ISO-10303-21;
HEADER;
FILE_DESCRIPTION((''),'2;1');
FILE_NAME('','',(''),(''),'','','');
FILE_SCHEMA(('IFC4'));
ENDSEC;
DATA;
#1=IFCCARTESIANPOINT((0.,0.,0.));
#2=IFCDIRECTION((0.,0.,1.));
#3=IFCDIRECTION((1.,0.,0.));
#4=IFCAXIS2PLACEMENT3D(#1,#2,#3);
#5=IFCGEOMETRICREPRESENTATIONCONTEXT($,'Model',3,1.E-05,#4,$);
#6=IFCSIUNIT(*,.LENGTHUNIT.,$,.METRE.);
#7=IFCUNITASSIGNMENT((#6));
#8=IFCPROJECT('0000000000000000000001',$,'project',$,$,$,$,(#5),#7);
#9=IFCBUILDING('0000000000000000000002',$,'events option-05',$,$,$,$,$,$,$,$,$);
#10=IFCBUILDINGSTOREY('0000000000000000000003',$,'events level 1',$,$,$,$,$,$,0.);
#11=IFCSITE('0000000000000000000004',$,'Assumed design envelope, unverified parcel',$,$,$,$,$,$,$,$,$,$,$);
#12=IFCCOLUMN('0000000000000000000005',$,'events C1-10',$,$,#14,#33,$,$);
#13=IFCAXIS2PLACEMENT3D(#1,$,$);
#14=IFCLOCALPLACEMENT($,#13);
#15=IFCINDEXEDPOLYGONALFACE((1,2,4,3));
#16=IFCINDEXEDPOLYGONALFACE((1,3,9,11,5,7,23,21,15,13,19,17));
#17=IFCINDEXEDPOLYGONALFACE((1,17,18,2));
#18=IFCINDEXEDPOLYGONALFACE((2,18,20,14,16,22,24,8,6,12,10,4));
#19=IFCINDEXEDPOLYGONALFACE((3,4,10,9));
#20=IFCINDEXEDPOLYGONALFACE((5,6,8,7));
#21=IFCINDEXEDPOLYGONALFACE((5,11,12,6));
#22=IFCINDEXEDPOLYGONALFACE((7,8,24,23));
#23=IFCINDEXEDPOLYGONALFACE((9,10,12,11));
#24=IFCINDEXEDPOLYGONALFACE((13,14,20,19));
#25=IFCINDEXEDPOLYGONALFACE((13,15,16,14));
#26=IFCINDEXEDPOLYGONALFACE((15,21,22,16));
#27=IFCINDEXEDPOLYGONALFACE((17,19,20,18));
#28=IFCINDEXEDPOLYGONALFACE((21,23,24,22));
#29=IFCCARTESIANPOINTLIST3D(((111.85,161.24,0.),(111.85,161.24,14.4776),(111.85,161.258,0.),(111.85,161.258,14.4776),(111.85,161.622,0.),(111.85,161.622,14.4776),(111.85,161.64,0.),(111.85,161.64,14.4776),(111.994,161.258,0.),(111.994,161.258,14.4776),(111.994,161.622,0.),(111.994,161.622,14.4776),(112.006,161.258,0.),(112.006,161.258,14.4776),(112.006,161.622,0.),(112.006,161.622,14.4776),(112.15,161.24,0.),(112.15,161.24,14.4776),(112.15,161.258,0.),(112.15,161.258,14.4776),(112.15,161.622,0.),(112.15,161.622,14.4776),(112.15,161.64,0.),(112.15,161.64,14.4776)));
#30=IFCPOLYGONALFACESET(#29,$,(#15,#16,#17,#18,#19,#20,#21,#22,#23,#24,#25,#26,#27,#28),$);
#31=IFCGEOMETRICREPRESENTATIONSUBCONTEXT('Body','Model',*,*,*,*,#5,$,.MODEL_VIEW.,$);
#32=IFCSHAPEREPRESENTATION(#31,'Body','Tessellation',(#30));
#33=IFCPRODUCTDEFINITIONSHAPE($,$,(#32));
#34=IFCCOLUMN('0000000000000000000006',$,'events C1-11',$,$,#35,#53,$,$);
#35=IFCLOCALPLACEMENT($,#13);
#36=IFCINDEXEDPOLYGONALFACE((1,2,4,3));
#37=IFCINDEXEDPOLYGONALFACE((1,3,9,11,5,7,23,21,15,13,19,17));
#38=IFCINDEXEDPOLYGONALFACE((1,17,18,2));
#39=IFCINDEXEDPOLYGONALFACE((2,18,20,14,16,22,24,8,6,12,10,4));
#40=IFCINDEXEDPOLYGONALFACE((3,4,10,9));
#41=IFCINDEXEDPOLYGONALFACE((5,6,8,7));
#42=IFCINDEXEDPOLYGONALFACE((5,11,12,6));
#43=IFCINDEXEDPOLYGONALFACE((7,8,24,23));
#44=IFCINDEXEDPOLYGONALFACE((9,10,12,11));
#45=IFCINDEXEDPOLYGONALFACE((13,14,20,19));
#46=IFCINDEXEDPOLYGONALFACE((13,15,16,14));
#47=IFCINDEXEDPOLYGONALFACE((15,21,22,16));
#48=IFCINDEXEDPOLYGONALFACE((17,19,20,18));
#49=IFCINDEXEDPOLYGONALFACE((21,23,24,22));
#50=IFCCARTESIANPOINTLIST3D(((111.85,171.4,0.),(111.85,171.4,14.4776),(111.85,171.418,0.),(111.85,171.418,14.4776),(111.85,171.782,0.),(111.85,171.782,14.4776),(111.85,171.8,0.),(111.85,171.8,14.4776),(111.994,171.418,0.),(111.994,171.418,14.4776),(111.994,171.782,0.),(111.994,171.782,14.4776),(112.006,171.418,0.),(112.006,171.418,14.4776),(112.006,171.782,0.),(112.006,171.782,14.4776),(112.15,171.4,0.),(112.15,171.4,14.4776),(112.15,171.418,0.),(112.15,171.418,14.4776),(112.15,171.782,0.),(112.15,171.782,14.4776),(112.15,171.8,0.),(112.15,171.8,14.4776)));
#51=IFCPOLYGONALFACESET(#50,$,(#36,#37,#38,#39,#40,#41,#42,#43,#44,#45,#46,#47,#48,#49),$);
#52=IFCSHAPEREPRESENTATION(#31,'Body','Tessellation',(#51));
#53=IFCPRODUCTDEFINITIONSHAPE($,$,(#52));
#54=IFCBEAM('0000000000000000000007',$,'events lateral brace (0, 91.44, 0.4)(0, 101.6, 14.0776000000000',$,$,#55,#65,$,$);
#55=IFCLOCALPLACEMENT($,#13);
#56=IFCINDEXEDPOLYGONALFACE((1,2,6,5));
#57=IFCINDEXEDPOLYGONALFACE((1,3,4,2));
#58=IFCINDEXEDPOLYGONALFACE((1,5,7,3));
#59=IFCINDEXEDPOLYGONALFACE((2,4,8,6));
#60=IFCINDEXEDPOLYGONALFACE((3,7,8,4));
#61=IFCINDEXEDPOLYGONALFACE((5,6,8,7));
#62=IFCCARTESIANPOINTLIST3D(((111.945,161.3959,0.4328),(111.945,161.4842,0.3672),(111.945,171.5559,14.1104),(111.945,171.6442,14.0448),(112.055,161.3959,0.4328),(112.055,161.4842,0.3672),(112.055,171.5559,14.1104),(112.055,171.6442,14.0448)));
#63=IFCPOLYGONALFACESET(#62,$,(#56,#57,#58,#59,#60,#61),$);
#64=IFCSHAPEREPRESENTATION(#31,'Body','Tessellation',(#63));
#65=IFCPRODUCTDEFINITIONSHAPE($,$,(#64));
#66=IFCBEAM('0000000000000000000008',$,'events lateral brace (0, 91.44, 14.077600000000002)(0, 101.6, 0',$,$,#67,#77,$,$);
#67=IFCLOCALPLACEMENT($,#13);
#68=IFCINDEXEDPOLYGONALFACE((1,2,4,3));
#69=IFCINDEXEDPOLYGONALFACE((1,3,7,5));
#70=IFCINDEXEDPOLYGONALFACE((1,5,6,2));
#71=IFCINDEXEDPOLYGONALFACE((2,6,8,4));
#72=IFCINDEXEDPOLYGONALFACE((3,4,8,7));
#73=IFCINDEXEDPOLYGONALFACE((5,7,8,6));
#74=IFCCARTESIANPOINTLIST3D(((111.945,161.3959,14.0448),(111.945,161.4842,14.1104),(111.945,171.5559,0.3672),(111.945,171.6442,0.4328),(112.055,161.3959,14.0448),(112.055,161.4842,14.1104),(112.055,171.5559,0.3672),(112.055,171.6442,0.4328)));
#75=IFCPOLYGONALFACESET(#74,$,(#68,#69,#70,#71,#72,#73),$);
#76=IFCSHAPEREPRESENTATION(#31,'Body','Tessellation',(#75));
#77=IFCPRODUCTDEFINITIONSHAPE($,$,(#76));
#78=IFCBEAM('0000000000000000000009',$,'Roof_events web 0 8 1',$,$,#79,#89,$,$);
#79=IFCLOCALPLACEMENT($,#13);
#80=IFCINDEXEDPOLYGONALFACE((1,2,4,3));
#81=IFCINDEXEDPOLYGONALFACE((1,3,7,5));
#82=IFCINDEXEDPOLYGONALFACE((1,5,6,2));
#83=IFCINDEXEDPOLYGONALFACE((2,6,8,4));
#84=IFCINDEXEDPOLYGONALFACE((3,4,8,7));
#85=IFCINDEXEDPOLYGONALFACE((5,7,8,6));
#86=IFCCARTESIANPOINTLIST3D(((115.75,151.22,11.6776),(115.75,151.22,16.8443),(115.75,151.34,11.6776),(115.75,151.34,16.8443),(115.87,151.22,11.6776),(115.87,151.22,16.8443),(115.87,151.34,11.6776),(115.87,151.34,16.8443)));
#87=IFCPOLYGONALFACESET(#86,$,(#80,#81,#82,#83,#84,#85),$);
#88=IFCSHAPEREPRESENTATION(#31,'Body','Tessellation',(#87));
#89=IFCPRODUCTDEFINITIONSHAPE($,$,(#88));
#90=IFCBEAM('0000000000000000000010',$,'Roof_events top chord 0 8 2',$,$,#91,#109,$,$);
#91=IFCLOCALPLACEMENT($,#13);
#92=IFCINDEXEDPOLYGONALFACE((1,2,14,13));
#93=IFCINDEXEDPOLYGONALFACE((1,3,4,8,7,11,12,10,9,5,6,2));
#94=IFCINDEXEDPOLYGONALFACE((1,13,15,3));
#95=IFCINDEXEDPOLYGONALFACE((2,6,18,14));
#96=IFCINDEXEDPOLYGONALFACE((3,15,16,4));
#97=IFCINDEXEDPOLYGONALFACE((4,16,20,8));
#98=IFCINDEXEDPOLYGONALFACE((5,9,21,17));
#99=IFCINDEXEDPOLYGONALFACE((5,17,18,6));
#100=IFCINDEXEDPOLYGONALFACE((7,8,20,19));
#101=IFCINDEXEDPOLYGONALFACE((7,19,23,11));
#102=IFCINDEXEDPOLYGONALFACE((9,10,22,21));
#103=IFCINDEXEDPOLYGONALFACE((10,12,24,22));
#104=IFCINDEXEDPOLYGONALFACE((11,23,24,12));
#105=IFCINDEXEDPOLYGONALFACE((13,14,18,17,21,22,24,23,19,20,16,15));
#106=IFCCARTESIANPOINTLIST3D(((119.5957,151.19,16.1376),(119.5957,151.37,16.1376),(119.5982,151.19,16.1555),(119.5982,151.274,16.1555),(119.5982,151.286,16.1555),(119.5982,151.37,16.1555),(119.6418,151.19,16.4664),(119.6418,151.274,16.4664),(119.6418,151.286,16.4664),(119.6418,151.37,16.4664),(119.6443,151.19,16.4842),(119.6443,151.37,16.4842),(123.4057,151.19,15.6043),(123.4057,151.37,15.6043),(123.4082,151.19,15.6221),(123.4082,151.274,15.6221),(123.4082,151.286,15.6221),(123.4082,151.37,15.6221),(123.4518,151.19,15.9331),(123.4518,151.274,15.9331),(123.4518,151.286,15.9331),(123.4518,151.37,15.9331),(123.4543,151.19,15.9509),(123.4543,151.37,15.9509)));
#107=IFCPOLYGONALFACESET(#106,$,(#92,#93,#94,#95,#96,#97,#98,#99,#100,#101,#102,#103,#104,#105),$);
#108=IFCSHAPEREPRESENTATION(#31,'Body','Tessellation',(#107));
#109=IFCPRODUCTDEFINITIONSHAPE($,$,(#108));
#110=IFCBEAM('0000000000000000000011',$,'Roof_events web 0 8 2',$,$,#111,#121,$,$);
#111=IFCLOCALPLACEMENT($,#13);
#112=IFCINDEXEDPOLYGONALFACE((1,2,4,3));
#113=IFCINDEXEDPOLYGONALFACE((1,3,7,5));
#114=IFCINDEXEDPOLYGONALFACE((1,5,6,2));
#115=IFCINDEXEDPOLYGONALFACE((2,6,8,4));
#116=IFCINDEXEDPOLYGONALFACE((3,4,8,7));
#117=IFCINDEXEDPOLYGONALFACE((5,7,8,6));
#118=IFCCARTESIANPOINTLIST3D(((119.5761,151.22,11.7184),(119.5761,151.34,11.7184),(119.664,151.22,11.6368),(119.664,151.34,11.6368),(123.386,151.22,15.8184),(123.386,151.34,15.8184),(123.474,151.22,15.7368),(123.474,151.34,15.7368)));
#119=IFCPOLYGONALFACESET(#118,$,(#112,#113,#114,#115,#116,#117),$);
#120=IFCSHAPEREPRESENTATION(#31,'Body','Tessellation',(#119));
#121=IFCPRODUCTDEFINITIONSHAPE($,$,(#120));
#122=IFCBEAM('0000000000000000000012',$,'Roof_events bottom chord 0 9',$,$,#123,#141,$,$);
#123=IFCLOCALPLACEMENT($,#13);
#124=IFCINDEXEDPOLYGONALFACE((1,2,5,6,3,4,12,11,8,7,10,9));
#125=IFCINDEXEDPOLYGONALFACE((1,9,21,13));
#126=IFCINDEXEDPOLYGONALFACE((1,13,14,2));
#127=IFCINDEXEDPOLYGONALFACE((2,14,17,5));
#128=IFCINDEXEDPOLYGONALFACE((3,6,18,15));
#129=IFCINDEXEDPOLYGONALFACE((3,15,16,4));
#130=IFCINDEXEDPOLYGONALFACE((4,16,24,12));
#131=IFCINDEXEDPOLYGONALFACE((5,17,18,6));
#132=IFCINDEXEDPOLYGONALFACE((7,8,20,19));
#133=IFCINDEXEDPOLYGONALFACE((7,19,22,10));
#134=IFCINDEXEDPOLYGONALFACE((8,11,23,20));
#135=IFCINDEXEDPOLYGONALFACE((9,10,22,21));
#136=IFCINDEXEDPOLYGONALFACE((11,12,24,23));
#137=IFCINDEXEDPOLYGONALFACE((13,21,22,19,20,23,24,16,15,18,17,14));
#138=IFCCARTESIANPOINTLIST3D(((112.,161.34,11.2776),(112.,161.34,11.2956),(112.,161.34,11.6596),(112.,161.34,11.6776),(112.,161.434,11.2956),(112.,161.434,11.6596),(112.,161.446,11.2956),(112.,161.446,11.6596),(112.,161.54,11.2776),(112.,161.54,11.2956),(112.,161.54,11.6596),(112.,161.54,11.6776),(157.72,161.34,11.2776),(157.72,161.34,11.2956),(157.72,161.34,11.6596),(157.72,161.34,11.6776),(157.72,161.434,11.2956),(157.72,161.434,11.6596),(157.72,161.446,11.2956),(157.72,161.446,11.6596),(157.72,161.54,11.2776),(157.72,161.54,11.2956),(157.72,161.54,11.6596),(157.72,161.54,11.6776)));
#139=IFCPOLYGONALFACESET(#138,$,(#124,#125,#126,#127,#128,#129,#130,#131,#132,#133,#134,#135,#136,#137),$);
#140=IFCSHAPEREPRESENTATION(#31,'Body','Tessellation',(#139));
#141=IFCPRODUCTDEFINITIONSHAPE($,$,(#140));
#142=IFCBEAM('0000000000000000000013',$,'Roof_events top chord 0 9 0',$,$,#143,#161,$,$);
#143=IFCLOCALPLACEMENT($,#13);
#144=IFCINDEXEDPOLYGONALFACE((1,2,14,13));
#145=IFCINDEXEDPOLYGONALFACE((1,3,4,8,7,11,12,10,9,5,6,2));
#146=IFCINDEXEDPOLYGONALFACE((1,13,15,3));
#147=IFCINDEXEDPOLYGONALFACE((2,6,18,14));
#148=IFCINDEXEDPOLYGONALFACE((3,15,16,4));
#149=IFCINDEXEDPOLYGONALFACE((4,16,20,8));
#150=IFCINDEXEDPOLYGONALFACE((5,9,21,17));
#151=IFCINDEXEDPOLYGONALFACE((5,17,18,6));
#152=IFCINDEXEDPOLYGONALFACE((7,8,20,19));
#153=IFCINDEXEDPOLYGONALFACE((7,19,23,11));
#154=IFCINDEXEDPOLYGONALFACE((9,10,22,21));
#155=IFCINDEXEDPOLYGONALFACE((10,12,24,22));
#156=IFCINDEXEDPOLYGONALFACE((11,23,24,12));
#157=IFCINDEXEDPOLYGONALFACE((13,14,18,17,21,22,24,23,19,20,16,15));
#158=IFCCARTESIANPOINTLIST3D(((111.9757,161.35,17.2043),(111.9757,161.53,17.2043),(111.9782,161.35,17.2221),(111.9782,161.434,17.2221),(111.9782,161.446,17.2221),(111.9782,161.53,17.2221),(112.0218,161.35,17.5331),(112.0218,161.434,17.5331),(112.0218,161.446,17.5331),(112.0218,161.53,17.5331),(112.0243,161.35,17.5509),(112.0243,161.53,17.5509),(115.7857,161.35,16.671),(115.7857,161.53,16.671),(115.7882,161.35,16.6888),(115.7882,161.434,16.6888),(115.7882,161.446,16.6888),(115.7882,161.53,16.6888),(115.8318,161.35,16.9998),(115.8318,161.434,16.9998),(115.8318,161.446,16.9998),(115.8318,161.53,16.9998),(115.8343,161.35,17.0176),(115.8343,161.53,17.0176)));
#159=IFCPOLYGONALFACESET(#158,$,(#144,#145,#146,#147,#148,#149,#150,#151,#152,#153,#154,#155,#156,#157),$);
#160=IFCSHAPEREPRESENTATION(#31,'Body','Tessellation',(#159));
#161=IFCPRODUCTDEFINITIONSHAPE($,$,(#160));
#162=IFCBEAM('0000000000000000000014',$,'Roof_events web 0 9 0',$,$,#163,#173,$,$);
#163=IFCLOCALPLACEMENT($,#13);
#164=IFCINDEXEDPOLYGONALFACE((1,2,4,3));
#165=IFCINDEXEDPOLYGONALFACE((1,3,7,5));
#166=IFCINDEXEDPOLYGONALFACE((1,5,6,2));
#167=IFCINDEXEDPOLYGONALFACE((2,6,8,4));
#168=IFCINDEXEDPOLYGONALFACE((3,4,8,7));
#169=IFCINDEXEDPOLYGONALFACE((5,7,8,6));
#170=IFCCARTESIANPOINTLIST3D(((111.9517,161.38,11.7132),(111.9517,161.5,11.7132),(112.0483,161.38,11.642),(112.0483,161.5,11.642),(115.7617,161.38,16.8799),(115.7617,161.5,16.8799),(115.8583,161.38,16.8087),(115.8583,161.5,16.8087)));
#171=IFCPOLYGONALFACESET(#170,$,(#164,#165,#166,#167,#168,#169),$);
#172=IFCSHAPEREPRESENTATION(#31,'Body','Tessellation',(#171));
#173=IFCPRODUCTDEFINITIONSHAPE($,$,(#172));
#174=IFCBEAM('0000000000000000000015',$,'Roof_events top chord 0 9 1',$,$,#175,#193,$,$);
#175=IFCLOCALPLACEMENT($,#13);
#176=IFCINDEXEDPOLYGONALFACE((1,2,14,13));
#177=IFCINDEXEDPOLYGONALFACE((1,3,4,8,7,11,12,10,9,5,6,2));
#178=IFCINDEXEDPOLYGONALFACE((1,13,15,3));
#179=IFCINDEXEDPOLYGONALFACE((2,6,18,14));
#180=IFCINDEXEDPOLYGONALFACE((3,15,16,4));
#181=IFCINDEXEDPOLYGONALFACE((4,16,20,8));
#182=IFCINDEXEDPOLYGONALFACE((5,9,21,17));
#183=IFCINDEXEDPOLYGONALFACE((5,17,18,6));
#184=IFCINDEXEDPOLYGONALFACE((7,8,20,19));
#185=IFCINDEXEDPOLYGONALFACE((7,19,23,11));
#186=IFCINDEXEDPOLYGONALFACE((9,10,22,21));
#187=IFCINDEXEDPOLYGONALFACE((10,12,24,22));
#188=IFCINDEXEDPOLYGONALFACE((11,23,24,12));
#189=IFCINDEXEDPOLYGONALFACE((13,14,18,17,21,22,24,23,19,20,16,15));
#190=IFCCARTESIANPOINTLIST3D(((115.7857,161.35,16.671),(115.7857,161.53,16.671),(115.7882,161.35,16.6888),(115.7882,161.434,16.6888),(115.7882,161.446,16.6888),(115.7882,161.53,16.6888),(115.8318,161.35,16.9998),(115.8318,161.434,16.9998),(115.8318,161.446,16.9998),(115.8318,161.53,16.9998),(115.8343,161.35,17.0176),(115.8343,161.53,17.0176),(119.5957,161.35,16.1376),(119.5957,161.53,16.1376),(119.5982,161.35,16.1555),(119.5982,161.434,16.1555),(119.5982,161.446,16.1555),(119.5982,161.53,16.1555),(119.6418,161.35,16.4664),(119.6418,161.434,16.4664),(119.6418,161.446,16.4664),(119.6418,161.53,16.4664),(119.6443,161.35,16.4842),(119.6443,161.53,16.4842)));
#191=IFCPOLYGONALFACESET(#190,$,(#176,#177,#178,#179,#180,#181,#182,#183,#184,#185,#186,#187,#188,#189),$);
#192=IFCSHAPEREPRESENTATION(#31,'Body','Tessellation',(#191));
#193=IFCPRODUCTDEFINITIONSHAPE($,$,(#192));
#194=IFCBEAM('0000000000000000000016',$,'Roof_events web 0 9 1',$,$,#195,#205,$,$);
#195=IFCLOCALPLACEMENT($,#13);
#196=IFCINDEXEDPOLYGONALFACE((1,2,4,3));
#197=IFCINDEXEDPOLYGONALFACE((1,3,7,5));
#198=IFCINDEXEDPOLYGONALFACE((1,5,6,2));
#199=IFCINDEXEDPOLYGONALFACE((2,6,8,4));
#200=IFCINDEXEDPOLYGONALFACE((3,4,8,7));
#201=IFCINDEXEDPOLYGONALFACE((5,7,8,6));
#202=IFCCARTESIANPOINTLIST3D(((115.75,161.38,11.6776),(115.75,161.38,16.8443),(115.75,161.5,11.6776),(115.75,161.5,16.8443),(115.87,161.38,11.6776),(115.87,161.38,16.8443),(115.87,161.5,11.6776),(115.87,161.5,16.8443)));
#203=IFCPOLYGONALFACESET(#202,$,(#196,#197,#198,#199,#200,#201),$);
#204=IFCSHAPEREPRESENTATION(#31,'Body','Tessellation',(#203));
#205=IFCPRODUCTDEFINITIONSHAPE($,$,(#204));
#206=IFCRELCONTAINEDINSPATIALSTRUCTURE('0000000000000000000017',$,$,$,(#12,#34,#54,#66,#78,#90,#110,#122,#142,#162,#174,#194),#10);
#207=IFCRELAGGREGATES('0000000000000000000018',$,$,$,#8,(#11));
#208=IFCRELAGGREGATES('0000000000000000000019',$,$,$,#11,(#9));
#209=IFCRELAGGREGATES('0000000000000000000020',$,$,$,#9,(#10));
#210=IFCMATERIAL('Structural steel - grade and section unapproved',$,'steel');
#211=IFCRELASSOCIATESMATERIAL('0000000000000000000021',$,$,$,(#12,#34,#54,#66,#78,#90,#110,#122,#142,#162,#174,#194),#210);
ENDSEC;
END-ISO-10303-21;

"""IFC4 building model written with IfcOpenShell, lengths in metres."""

from ifc_helpers import new_model, si_unit, frame, origin_with_axes, place, context, subcontext, project, spatial, rectangle, i_section, extrude, material, element, save


model = new_model("IFC4")

# Units and contexts
model_context = context("Model", 3, precision=1e-05, world=origin_with_axes())
body_context = subcontext(model_context, "Body", "Model", "MODEL_VIEW")
ifc_project = project(units=[si_unit("LENGTHUNIT", "METRE")], contexts=[model_context])

# Site, building, storey
site = spatial("IfcSite", under=ifc_project, Name="Assumed design envelope, unverified parcel")
building = spatial("IfcBuilding", under=site, Name="events option-05")
storey = spatial("IfcBuildingStorey", under=building, Name="events level 1", Elevation=0.0)

# Columns
ifc_material_1 = material(Name="Structural steel - grade and section unapproved", Category="steel")
for number, where, z_axis, x_axis, name in (
    (1, (112.0, 161.44, 0.0), (0.0, 0.0, 1.0), (-1.0, 0.0, 0.0), "events C1-10"),
    (2, (112.0, 171.6, 0.0), (0.0, 0.0, 1.0), (-1.0, 0.0, 0.0), "events C1-11"),
):
    element("IfcColumn", number, at=place(None, frame(where, z_axis=z_axis, x_axis=x_axis)), inside=storey, material=ifc_material_1, Name=name, context=body_context, shape_type="SweptSolid", body=[
        extrude(i_section(OverallWidth=0.3, OverallDepth=0.4, WebThickness=0.012, FlangeThickness=0.018, FilletRadius=0.0), origin_with_axes(), (0.0, 0.0, 1.0), 14.4776),
    ])

# Beams
for number, where, z_axis, x_axis, name in (
    (3, (112.0, 161.44, 0.4), (0.0, 0.596305, 0.802758), (-1.0, 0.0, 0.0), "events lateral brace (0, 91.44, 0.4)(0, 101.6, 14.0776000000000"),
    (4, (112.0, 161.44, 14.0776), (0.0, 0.596305, -0.802758), (-1.0, 0.0, 0.0), "events lateral brace (0, 91.44, 14.077600000000002)(0, 101.6, 0"),
):
    element("IfcBeam", number, at=place(None, frame(where, z_axis=z_axis, x_axis=x_axis)), inside=storey, material=ifc_material_1, Name=name, context=body_context, shape_type="SweptSolid", body=[
        extrude(rectangle(XDim=0.11, YDim=0.11), origin_with_axes(), (0.0, 0.0, 1.0), 17.0383),
    ])
beam_1_placement = place(None, frame((115.81, 151.28, 11.6776), z_axis=(0.0, 0.0, 1.0), x_axis=(-1.0, 0.0, 0.0)))
element("IfcBeam", 5, at=beam_1_placement, inside=storey, material=ifc_material_1, Name="Roof_events web 0 8 1", context=body_context, shape_type="SweptSolid", body=[
    extrude(rectangle(XDim=0.12, YDim=0.12), origin_with_axes(), (0.0, 0.0, 1.0), 5.1667),
])
beam_2_placement = place(None, frame((119.62, 151.28, 16.3109), z_axis=(0.990344, 0.0, -0.138631), x_axis=(0.0, 1.0, 0.0)))
element("IfcBeam", 6, at=beam_2_placement, inside=storey, material=ifc_material_1, Name="Roof_events top chord 0 8 2", context=body_context, shape_type="SweptSolid", body=[
    extrude(i_section(OverallWidth=0.18, OverallDepth=0.35, WebThickness=0.012, FlangeThickness=0.018, FilletRadius=0.0), origin_with_axes(), (0.0, 0.0, 1.0), 3.8471),
])
beam_3_placement = place(None, frame((119.62, 151.28, 11.6776), z_axis=(0.680725, 0.0, 0.732539), x_axis=(0.0, 1.0, 0.0)))
element("IfcBeam", 7, at=beam_3_placement, inside=storey, material=ifc_material_1, Name="Roof_events web 0 8 2", context=body_context, shape_type="SweptSolid", body=[
    extrude(rectangle(XDim=0.12, YDim=0.12), origin_with_axes(), (0.0, 0.0, 1.0), 5.597),
])
beam_4_placement = place(None, frame((112.0, 161.44, 11.4776), z_axis=(1.0, 0.0, 0.0), x_axis=(0.0, 1.0, 0.0)))
element("IfcBeam", 8, at=beam_4_placement, inside=storey, material=ifc_material_1, Name="Roof_events bottom chord 0 9", context=body_context, shape_type="SweptSolid", body=[
    extrude(i_section(OverallWidth=0.2, OverallDepth=0.4, WebThickness=0.012, FlangeThickness=0.018, FilletRadius=0.0), origin_with_axes(), (0.0, 0.0, 1.0), 45.72),
])
beam_5_placement = place(None, frame((112.0, 161.44, 17.3776), z_axis=(0.990344, 0.0, -0.138631), x_axis=(0.0, 1.0, 0.0)))
element("IfcBeam", 9, at=beam_5_placement, inside=storey, material=ifc_material_1, Name="Roof_events top chord 0 9 0", context=body_context, shape_type="SweptSolid", body=[
    extrude(i_section(OverallWidth=0.18, OverallDepth=0.35, WebThickness=0.012, FlangeThickness=0.018, FilletRadius=0.0), origin_with_axes(), (0.0, 0.0, 1.0), 3.8471),
])
beam_6_placement = place(None, frame((112.0, 161.44, 11.6776), z_axis=(0.5935, 0.0, 0.804834), x_axis=(0.0, 1.0, 0.0)))
element("IfcBeam", 10, at=beam_6_placement, inside=storey, material=ifc_material_1, Name="Roof_events web 0 9 0", context=body_context, shape_type="SweptSolid", body=[
    extrude(rectangle(XDim=0.12, YDim=0.12), origin_with_axes(), (0.0, 0.0, 1.0), 6.4195),
])
beam_7_placement = place(None, frame((115.81, 161.44, 16.8443), z_axis=(0.990344, 0.0, -0.138631), x_axis=(0.0, 1.0, 0.0)))
element("IfcBeam", 11, at=beam_7_placement, inside=storey, material=ifc_material_1, Name="Roof_events top chord 0 9 1", context=body_context, shape_type="SweptSolid", body=[
    extrude(i_section(OverallWidth=0.18, OverallDepth=0.35, WebThickness=0.012, FlangeThickness=0.018, FilletRadius=0.0), origin_with_axes(), (0.0, 0.0, 1.0), 3.8472),
])
beam_8_placement = place(None, frame((115.81, 161.44, 11.6776), z_axis=(0.0, 0.0, 1.0), x_axis=(-1.0, 0.0, 0.0)))
element("IfcBeam", 12, at=beam_8_placement, inside=storey, material=ifc_material_1, Name="Roof_events web 0 9 1", context=body_context, shape_type="SweptSolid", body=[
    extrude(rectangle(XDim=0.12, YDim=0.12), origin_with_axes(), (0.0, 0.0, 1.0), 5.1667),
])

save(model, "model.ifc")
